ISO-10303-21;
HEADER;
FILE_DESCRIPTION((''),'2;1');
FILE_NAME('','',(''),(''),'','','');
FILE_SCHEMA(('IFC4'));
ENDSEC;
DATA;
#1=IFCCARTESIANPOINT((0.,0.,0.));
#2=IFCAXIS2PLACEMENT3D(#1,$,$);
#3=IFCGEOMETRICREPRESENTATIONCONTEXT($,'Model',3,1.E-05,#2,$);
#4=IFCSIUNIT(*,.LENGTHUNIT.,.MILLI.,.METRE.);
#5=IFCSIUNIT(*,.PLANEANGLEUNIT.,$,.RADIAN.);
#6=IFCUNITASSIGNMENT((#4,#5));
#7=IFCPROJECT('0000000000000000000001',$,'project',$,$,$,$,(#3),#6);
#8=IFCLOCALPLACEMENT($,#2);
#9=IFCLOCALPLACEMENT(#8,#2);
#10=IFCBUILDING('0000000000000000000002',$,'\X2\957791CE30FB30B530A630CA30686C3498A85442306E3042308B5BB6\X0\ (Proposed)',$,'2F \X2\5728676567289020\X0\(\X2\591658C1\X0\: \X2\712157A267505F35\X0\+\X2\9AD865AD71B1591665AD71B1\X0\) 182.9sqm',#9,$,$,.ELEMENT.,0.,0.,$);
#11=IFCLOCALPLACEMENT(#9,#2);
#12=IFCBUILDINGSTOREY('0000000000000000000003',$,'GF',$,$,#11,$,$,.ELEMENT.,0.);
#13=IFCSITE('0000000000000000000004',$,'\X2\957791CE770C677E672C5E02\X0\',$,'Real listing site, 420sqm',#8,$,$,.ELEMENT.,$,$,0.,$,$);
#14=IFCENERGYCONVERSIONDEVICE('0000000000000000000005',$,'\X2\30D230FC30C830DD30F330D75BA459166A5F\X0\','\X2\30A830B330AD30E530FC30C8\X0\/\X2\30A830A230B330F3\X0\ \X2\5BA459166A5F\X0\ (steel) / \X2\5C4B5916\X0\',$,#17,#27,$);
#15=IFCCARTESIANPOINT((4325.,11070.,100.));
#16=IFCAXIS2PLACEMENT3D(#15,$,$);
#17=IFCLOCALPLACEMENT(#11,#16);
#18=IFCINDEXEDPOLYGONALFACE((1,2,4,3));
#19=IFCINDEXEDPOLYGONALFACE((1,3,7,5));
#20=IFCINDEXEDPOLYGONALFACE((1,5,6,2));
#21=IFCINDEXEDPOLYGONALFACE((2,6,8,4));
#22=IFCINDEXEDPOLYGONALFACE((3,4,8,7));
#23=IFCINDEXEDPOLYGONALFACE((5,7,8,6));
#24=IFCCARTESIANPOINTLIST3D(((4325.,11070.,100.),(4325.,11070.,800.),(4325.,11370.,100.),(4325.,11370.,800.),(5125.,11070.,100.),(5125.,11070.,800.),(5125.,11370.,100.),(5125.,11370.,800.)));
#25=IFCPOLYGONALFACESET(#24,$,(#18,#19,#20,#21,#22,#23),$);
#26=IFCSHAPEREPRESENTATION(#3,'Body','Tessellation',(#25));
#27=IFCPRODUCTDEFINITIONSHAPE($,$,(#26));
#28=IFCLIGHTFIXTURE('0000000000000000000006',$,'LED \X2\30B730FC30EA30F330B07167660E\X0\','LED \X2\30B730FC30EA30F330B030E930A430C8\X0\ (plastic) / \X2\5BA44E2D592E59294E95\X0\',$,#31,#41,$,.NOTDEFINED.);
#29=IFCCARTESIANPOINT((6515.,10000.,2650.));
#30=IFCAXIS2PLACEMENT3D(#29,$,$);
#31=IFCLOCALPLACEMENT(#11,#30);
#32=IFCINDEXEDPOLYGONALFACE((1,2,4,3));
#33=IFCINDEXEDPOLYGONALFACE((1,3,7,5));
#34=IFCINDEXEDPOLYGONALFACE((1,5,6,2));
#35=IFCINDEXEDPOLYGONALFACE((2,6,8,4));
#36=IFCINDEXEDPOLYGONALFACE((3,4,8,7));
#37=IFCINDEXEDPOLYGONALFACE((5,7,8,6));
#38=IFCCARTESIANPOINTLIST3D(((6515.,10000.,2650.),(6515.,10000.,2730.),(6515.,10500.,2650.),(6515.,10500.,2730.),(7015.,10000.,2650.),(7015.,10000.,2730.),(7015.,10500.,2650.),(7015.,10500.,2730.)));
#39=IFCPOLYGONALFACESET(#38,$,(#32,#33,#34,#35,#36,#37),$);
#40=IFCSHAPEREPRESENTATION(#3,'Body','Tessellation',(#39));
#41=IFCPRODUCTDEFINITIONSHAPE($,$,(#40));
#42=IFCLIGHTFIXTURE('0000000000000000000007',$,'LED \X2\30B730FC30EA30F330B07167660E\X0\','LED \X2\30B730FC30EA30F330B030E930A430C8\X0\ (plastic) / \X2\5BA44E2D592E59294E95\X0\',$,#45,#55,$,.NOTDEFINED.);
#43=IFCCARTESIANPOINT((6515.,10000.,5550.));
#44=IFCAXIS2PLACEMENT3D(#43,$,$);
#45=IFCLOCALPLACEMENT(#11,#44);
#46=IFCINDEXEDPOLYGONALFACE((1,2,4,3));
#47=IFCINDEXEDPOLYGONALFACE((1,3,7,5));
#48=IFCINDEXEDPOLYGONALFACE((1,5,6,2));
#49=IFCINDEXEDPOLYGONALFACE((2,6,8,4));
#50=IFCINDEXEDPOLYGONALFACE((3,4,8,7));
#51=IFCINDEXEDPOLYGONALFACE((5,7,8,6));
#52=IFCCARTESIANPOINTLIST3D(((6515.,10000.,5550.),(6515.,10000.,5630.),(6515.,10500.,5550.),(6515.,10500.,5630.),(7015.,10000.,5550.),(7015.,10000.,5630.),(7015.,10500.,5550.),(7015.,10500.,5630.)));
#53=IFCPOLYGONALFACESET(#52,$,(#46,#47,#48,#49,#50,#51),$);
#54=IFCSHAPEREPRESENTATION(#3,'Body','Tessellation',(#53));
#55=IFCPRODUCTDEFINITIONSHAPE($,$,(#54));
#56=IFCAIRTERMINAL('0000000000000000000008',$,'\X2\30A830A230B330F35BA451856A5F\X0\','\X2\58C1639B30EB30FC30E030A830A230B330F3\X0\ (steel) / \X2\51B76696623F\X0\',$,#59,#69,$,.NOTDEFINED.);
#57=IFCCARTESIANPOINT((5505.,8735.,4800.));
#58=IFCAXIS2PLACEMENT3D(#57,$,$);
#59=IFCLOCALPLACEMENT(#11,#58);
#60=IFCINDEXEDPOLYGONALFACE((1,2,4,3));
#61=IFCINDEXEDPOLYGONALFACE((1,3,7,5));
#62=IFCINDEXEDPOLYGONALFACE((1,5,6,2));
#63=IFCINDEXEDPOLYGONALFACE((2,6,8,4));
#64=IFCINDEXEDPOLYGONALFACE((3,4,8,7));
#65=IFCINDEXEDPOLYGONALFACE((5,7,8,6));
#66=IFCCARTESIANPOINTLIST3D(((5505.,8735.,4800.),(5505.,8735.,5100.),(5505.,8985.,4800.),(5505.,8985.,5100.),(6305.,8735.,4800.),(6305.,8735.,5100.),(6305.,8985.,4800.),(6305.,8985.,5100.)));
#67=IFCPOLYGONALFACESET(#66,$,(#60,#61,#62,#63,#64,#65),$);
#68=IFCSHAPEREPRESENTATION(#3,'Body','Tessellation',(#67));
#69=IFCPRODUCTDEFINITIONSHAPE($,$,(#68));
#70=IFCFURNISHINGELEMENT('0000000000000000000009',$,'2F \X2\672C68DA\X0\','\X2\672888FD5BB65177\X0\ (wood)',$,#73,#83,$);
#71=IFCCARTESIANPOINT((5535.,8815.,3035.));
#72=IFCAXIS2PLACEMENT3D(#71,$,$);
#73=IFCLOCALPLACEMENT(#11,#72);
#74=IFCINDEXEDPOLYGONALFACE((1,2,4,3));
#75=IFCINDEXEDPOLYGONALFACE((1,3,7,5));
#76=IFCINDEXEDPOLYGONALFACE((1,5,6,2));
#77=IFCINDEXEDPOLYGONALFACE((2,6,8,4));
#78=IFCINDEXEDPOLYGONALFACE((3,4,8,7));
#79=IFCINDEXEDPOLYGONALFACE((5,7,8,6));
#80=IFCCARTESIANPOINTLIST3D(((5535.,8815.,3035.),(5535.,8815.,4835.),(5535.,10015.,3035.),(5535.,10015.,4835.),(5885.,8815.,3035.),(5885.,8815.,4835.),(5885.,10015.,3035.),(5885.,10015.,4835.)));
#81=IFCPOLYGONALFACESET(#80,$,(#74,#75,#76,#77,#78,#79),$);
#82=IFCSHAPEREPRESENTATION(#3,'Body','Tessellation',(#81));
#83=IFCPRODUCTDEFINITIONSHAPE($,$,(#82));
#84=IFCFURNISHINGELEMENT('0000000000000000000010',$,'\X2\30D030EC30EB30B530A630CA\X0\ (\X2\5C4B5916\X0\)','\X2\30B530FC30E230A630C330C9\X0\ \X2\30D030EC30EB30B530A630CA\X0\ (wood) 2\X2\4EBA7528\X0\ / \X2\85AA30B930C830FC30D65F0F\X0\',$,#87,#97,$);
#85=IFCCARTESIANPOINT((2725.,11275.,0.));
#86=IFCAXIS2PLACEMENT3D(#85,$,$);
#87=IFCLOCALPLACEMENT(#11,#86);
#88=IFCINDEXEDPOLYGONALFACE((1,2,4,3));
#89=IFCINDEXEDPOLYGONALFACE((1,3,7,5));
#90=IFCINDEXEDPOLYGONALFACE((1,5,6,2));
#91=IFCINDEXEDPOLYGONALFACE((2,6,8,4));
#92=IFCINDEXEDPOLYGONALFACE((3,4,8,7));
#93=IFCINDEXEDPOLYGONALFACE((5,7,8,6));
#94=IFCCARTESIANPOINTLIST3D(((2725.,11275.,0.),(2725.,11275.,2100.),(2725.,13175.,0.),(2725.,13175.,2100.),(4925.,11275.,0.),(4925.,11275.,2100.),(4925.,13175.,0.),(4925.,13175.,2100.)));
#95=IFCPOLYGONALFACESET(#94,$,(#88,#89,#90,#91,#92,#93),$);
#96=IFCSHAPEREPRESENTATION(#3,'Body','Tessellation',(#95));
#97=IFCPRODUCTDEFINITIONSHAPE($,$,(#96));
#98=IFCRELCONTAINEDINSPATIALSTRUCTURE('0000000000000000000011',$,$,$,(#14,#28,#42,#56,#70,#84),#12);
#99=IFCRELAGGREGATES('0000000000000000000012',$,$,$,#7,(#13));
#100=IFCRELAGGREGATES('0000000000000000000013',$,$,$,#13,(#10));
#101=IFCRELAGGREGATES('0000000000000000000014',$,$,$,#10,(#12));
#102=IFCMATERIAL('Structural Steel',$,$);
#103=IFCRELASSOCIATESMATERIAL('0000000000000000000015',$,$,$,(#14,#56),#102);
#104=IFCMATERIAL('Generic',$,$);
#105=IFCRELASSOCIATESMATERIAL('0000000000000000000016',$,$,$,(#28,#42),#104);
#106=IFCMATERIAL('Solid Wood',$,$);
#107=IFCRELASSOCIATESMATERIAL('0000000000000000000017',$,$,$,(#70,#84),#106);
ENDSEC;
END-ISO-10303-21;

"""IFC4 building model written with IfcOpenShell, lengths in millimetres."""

from ifc_helpers import new_model, si_unit, frame, frame_2d, origin, place, context, project, spatial, rectangle, extrude, material, element, save


model = new_model("IFC4")

# Units and contexts
model_context = context("Model", 3, precision=1e-05, world=origin())
ifc_project = project(units=[si_unit("LENGTHUNIT", "METRE", prefix="MILLI"), si_unit("PLANEANGLEUNIT", "RADIAN")], contexts=[model_context])

# Site, building, storey
site_placement = place(None, origin())
site = spatial("IfcSite", under=ifc_project, at=site_placement, Name="長野県松本市", ObjectType="Real listing site, 420sqm", CompositionType="ELEMENT", RefElevation=0.0)
building_placement = place(site_placement, origin())
building = spatial("IfcBuilding", under=site, at=building_placement, Name="長野・サウナと水風呂のある家 (Proposed)", ObjectType="2F 在来木造(外壁: 無垢材張+高断熱外断熱) 182.9sqm", CompositionType="ELEMENT", ElevationOfRefHeight=0.0, ElevationOfTerrain=0.0)
storey_placement = place(building_placement, origin())
storey = spatial("IfcBuildingStorey", under=building, at=storey_placement, Name="GF", CompositionType="ELEMENT", Elevation=0.0)

# Shared definitions
ifc_material_1 = material(Name="Solid Wood")

# Shared definitions
ifc_material_2 = material(Name="Structural Steel")

# Shared definitions
ifc_material_3 = material(Name="Generic")

# Energy conversion device
energy_conversion_device_placement = place(storey_placement, frame((4325.0, 11070.0, 100.0)))
element("IfcEnergyConversionDevice", 1, at=energy_conversion_device_placement, inside=storey, material=ifc_material_2, Name="ヒートポンプ室外機", Description="エコキュート/エアコン 室外機 (steel) / 屋外", context=model_context, shape_type="SweptSolid", body=[
    extrude(rectangle(XDim=800.0, YDim=300.0, at=frame_2d((400.0, 150.0))), frame((4325.0, 11070.0, 100.0)), (0.0, 0.0, 1.0), 700.0),
])

# Light fixtures
light_fixture_1_placement = place(storey_placement, frame((6515.0, 10000.0, 2650.0)))
element("IfcLightFixture", 2, at=light_fixture_1_placement, inside=storey, material=ifc_material_3, Name="LED シーリング照明", Description="LED シーリングライト (plastic) / 室中央天井", PredefinedType="NOTDEFINED", context=model_context, shape_type="SweptSolid", body=[
    extrude(rectangle(XDim=500.0, YDim=500.0, at=frame_2d((250.0, 250.0))), frame((6515.0, 10000.0, 2650.0)), (0.0, 0.0, 1.0), 80.0),
])
light_fixture_2_placement = place(storey_placement, frame((6515.0, 10000.0, 5550.0)))
element("IfcLightFixture", 3, at=light_fixture_2_placement, inside=storey, material=ifc_material_3, Name="LED シーリング照明", Description="LED シーリングライト (plastic) / 室中央天井", PredefinedType="NOTDEFINED", context=model_context, shape_type="SweptSolid", body=[
    extrude(rectangle(XDim=500.0, YDim=500.0, at=frame_2d((250.0, 250.0))), frame((6515.0, 10000.0, 5550.0)), (0.0, 0.0, 1.0), 80.0),
])

# Air terminal
air_terminal_placement = place(storey_placement, frame((5505.0, 8735.0, 4800.0)))
element("IfcAirTerminal", 4, at=air_terminal_placement, inside=storey, material=ifc_material_2, Name="エアコン室内機", Description="壁掛ルームエアコン (steel) / 冷暖房", PredefinedType="NOTDEFINED", context=model_context, shape_type="SweptSolid", body=[
    extrude(rectangle(XDim=800.0, YDim=250.0, at=frame_2d((400.0, 125.0))), frame((5505.0, 8735.0, 4800.0)), (0.0, 0.0, 1.0), 300.0),
])

# Furnishing elements
furnishing_1_placement = place(storey_placement, frame((5535.0, 8815.0, 3035.0)))
element("IfcFurnishingElement", 5, at=furnishing_1_placement, inside=storey, material=ifc_material_1, Name="2F 本棚", Description="木製家具 (wood)", context=model_context, shape_type="SweptSolid", body=[
    extrude(rectangle(XDim=350.0, YDim=1200.0, at=frame_2d((175.0, 600.0))), frame((5535.0, 8815.0, 3035.0)), (0.0, 0.0, 1.0), 1800.0),
])
furnishing_2_placement = place(storey_placement, frame((2725.0, 11275.0, 0.0)))
element("IfcFurnishingElement", 6, at=furnishing_2_placement, inside=storey, material=ifc_material_1, Name="バレルサウナ (屋外)", Description="サーモウッド バレルサウナ (wood) 2人用 / 薪ストーブ式", context=model_context, shape_type="SweptSolid", body=[
    extrude(rectangle(XDim=2200.0, YDim=1900.0, at=frame_2d((1100.0, 950.0))), frame((2725.0, 11275.0, 0.0)), (0.0, 0.0, 1.0), 2100.0),
])

save(model, "model.ifc")
